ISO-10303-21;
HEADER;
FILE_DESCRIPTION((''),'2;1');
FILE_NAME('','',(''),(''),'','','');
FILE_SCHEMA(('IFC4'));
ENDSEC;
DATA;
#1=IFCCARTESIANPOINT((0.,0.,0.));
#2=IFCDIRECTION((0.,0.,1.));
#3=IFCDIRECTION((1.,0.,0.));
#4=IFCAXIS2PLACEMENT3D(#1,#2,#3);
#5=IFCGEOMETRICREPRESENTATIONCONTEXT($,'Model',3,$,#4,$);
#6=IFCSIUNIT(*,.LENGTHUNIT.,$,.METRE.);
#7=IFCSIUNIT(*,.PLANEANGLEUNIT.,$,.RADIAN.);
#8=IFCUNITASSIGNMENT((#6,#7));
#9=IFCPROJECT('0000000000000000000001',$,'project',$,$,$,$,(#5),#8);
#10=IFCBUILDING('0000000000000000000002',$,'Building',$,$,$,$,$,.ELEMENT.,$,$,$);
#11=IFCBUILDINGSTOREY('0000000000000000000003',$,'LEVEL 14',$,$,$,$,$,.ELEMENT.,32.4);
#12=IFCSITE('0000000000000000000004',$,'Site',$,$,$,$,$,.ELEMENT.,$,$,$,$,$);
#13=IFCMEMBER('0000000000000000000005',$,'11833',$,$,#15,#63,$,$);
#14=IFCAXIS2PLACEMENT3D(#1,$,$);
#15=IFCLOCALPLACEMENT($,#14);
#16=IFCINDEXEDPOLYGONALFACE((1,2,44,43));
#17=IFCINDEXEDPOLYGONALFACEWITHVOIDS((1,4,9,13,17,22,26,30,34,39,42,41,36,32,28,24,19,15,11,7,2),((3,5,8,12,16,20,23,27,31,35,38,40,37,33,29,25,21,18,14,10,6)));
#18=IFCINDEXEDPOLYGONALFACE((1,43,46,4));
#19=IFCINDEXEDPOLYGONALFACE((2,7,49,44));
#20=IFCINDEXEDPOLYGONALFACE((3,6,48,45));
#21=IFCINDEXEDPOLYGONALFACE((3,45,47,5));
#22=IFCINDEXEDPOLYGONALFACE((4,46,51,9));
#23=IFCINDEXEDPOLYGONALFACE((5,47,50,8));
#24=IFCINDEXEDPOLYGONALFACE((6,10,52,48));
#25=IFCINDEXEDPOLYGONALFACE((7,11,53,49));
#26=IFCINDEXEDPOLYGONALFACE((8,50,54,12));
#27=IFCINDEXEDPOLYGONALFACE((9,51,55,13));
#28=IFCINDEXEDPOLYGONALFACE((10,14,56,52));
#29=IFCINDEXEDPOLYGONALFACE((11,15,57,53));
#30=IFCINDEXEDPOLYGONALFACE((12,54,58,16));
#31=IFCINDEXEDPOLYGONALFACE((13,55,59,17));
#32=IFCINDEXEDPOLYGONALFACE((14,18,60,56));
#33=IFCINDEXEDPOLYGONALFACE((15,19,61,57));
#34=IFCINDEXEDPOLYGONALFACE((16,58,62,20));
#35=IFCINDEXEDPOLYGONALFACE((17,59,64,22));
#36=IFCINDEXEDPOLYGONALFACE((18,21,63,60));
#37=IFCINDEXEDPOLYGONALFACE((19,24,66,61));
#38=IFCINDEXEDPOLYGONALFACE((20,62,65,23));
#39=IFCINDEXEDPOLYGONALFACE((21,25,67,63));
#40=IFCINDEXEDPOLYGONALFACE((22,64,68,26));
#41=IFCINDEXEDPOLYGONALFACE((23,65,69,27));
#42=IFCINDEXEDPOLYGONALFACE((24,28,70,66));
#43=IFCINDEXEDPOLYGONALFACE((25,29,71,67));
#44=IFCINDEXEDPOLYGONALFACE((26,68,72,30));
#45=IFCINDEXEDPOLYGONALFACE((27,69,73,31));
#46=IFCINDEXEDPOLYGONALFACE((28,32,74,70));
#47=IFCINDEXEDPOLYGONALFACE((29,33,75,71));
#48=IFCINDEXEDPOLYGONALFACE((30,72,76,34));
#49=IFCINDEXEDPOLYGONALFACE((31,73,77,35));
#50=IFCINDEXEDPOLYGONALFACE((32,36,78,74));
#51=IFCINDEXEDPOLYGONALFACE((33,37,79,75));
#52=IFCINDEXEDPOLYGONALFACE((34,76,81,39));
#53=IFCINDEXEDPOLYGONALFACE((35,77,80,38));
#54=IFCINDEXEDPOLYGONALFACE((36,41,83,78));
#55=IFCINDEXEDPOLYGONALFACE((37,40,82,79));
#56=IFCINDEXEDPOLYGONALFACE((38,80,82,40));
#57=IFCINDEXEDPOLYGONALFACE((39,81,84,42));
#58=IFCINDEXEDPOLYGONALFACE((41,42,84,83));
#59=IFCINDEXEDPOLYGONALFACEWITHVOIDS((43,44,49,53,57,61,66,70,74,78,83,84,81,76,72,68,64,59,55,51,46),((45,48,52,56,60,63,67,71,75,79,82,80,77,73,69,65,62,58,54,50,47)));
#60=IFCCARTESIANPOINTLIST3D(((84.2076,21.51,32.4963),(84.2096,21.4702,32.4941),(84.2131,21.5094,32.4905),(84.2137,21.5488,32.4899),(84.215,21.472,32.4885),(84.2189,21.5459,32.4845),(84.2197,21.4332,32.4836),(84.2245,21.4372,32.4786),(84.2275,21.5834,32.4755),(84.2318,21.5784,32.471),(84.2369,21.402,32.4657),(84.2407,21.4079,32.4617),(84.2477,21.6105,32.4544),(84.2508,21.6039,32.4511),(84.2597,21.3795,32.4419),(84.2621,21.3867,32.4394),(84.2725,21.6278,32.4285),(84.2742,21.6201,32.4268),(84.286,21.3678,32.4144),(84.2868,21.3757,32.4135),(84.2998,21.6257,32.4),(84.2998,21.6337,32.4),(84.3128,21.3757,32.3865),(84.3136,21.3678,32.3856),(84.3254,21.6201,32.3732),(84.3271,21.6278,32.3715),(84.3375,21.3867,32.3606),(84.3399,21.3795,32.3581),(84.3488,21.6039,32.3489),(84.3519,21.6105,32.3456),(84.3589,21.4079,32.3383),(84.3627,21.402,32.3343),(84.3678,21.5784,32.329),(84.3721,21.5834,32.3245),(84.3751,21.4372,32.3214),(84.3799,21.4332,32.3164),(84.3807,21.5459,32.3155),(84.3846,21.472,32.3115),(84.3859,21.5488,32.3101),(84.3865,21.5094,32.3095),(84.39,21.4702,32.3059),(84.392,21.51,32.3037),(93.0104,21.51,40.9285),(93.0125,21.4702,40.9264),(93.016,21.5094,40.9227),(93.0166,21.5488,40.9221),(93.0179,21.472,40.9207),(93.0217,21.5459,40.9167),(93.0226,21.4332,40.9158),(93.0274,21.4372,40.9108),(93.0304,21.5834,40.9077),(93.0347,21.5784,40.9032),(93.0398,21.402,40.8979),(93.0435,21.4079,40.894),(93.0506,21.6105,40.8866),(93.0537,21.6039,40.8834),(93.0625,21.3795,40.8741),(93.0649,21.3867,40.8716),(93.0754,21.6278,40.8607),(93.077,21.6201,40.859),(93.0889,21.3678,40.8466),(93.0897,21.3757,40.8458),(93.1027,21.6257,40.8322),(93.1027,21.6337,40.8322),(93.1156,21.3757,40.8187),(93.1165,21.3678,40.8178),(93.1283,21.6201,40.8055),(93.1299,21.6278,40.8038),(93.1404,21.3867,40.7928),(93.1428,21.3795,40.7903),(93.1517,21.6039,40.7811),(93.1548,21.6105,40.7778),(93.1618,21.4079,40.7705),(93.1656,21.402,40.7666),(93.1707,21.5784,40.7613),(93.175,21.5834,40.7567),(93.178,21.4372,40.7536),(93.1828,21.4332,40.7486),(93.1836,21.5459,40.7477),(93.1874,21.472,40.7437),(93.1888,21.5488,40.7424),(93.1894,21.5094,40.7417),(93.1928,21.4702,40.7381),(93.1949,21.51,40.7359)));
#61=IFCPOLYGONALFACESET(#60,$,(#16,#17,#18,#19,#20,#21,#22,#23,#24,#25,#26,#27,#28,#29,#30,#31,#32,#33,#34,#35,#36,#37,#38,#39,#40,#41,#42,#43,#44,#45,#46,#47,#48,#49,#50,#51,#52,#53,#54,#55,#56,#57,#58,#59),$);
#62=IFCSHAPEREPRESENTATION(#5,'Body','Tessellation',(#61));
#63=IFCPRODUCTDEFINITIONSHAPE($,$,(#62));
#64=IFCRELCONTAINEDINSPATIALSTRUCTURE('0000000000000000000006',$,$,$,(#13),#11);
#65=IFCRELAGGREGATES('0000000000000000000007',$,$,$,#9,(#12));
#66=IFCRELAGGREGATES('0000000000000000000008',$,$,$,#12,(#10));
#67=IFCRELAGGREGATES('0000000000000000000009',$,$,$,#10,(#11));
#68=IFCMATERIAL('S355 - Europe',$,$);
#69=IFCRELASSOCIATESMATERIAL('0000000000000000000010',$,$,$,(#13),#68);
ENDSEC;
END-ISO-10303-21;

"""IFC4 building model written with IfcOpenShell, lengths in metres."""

from ifc_helpers import new_model, si_unit, frame, origin_with_axes, origin_2d_with_axis, place, context, project, spatial, hollow_circle, extrude, material, material_profile, profile_set, profile_usage, element, save


model = new_model("IFC4")

# Units and contexts
model_context = context("Model", 3, world=origin_with_axes())
ifc_project = project(units=[si_unit("LENGTHUNIT", "METRE"), si_unit("PLANEANGLEUNIT", "RADIAN")], contexts=[model_context])

# Site, building, storey
site = spatial("IfcSite", under=ifc_project, Name="Site", CompositionType="ELEMENT")
building = spatial("IfcBuilding", under=site, Name="Building", CompositionType="ELEMENT")
storey = spatial("IfcBuildingStorey", under=building, Name="LEVEL 14", CompositionType="ELEMENT", Elevation=32.4)

# Shared definitions
ifc_material = material(Name="S355 - Europe")

# Member
ifc_material_profile_1 = material_profile(ifc_material, hollow_circle(Radius=0.1337, WallThickness=0.008, at=origin_2d_with_axis()))
ifc_profile_set_1 = profile_set([ifc_material_profile_1])
ifc_profile_usage_1 = profile_usage(ifc_profile_set_1, cardinal=10)
member_1_placement = place(None, frame((84.2998, 21.5, 32.4), z_axis=(0.722146, 0.0, 0.69174), x_axis=(0.0, 1.0, 0.0)))
element("IfcMember", 1, at=member_1_placement, inside=storey, material=ifc_profile_usage_1, Name="11833", context=model_context, shape_type="SweptSolid", body=[
    extrude(hollow_circle(Radius=0.1337, WallThickness=0.008, at=origin_2d_with_axis()), origin_with_axes(), (0.0, 0.0, 1.0), 12.1899),
])

save(model, "model.ifc")
